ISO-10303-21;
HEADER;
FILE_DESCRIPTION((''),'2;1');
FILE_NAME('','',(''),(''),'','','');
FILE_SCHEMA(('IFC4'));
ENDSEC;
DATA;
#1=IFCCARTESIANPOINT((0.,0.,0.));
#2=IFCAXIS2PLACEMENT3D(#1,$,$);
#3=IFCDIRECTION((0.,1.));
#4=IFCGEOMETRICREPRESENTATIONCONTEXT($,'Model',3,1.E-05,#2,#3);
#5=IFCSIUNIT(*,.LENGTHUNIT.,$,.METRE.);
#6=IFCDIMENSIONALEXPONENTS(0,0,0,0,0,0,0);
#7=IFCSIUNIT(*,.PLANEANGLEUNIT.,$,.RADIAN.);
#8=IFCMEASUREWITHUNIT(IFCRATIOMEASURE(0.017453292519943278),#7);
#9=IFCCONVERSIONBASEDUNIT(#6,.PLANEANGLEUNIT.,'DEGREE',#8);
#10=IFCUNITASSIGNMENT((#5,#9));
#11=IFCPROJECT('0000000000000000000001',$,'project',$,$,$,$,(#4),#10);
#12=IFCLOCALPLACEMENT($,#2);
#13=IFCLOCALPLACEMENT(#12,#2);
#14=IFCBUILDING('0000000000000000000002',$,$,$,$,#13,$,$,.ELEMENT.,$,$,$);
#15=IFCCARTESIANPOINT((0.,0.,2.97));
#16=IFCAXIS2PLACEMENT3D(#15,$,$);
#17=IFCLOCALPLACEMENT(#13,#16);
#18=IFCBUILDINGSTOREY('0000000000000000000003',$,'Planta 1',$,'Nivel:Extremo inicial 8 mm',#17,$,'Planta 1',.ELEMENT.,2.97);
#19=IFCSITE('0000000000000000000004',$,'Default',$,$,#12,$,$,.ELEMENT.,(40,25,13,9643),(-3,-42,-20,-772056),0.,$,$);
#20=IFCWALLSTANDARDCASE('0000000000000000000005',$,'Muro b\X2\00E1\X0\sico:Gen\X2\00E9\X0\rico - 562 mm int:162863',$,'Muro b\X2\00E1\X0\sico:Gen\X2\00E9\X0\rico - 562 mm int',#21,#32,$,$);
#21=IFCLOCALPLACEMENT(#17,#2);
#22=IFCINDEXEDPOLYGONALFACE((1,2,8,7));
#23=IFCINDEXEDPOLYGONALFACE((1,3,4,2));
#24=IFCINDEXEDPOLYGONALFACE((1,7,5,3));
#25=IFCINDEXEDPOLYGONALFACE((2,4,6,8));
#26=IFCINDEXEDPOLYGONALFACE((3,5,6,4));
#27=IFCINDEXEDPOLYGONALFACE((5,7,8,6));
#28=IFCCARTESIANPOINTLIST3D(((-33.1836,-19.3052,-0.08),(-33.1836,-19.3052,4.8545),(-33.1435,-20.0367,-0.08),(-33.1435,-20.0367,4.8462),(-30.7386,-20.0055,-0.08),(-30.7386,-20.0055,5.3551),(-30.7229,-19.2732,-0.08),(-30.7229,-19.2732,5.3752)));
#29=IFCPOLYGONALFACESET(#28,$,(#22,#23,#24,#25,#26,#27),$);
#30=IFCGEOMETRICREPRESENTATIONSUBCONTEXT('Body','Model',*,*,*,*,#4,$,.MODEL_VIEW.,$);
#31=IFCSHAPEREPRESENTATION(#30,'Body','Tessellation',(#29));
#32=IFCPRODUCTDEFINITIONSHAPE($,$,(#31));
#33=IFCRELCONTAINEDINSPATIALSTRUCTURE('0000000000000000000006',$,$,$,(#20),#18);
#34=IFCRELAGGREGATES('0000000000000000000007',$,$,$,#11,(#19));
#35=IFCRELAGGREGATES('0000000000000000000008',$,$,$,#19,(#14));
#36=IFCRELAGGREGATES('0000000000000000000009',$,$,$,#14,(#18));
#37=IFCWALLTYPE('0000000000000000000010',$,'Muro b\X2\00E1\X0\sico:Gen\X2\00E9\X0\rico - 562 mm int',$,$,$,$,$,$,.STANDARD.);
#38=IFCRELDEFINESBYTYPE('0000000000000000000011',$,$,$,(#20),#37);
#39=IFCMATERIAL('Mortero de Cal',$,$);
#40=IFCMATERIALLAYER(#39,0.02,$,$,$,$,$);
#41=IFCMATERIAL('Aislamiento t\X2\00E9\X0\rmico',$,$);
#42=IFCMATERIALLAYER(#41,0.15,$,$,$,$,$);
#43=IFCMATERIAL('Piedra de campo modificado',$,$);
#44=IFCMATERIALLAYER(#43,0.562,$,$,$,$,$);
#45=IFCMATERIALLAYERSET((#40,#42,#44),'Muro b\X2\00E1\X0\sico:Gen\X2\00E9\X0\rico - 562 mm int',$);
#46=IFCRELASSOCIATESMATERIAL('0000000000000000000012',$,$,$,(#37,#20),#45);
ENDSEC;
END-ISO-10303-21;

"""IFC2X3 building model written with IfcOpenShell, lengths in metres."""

from ifc_helpers import new_model, entity, si_unit, converted_unit, direction, frame, origin, place, context, subcontext, project, spatial, polyline, outline, extrude, clip, bounded_halfspace, material, layer, layer_set, layer_usage, type_object, element, save


model = new_model("IFC2X3")

# Units and contexts
model_context = context("Model", 3, precision=1e-05, world=origin(), true_north=direction((0.0, 1.0)))
body_context = subcontext(model_context, "Body", "Model", "MODEL_VIEW")
ifc_project = project(units=[si_unit("LENGTHUNIT", "METRE"), converted_unit("PLANEANGLEUNIT", "DEGREE", entity("IfcRatioMeasure", 0.017453292519943278), si_unit("PLANEANGLEUNIT", "RADIAN"), dimensions=[0, 0, 0, 0, 0, 0, 0])], contexts=[model_context])

# Site, building, storey
site_placement = place(None, origin())
site = spatial("IfcSite", under=ifc_project, at=site_placement, Name="Default", CompositionType="ELEMENT", RefLatitude=(40, 25, 13, 9643), RefLongitude=(-3, -42, -20, -772056), RefElevation=0.0)
building_placement = place(site_placement, origin())
building = spatial("IfcBuilding", under=site, at=building_placement, CompositionType="ELEMENT")
storey_placement = place(building_placement, frame((0.0, 0.0, 2.97)))
storey = spatial("IfcBuildingStorey", under=building, at=storey_placement, Name="Planta 1", ObjectType="Nivel:Extremo inicial 8 mm", LongName="Planta 1", CompositionType="ELEMENT", Elevation=2.97)

# Shared definitions
ifc_material_1 = material(Name="Aislamiento térmico")

# Shared definitions
ifc_material_2 = material(Name="Mortero de Cal")

# Wall
ifc_layer_1 = layer(ifc_material_2, 0.02)
ifc_layer_2 = layer(ifc_material_1, 0.15)
ifc_material_3 = material(Name="Piedra de campo modificado")
ifc_layer_3 = layer(ifc_material_3, 0.562)
ifc_layer_set_1 = layer_set([ifc_layer_1, ifc_layer_2, ifc_layer_3], Name="Muro básico:Genérico - 562 mm int")
ifc_layer_usage_1 = layer_usage(ifc_layer_set_1, "AXIS2", "NEGATIVE", 0.366)
wall_type = type_object("IfcWallType", Name="Muro básico:Genérico - 562 mm int", PredefinedType="STANDARD", material=ifc_layer_set_1)
wall_placement = place(storey_placement, frame((-33.1788, -19.6711, -0.08), z_axis=(0.0, 0.0, 1.0), x_axis=(0.999916, 0.01299, 0.0)))
element("IfcWallStandardCase", 1, at=wall_placement, inside=storey, type_object=wall_type, material=ifc_layer_usage_1, Name="Muro básico:Genérico - 562 mm int:162863", ObjectType="Muro básico:Genérico - 562 mm int", context=body_context, shape_type="Clipping", body=[
    clip(extrude(outline(polyline([(2.4356, -0.366), (2.4609, 0.366), (0.0, 0.366), (0.0305, -0.366), (2.4356, -0.366)])), origin(), (0.0, 0.0, 1.0), 5.4552), bounded_halfspace(frame((0.0305, -0.366, 4.9262), z_axis=(-0.206975, -0.019717, 0.978148), x_axis=(0.094836, -0.995493, 0.0)), False, frame((0.0305, -0.366, 4.9262)), polyline([(0.0, 0.0), (2.4051, 0.0), (2.4303, 0.732), (-0.0305, 0.732), (0.0, 0.0)]))),
])

save(model, "model.ifc")
